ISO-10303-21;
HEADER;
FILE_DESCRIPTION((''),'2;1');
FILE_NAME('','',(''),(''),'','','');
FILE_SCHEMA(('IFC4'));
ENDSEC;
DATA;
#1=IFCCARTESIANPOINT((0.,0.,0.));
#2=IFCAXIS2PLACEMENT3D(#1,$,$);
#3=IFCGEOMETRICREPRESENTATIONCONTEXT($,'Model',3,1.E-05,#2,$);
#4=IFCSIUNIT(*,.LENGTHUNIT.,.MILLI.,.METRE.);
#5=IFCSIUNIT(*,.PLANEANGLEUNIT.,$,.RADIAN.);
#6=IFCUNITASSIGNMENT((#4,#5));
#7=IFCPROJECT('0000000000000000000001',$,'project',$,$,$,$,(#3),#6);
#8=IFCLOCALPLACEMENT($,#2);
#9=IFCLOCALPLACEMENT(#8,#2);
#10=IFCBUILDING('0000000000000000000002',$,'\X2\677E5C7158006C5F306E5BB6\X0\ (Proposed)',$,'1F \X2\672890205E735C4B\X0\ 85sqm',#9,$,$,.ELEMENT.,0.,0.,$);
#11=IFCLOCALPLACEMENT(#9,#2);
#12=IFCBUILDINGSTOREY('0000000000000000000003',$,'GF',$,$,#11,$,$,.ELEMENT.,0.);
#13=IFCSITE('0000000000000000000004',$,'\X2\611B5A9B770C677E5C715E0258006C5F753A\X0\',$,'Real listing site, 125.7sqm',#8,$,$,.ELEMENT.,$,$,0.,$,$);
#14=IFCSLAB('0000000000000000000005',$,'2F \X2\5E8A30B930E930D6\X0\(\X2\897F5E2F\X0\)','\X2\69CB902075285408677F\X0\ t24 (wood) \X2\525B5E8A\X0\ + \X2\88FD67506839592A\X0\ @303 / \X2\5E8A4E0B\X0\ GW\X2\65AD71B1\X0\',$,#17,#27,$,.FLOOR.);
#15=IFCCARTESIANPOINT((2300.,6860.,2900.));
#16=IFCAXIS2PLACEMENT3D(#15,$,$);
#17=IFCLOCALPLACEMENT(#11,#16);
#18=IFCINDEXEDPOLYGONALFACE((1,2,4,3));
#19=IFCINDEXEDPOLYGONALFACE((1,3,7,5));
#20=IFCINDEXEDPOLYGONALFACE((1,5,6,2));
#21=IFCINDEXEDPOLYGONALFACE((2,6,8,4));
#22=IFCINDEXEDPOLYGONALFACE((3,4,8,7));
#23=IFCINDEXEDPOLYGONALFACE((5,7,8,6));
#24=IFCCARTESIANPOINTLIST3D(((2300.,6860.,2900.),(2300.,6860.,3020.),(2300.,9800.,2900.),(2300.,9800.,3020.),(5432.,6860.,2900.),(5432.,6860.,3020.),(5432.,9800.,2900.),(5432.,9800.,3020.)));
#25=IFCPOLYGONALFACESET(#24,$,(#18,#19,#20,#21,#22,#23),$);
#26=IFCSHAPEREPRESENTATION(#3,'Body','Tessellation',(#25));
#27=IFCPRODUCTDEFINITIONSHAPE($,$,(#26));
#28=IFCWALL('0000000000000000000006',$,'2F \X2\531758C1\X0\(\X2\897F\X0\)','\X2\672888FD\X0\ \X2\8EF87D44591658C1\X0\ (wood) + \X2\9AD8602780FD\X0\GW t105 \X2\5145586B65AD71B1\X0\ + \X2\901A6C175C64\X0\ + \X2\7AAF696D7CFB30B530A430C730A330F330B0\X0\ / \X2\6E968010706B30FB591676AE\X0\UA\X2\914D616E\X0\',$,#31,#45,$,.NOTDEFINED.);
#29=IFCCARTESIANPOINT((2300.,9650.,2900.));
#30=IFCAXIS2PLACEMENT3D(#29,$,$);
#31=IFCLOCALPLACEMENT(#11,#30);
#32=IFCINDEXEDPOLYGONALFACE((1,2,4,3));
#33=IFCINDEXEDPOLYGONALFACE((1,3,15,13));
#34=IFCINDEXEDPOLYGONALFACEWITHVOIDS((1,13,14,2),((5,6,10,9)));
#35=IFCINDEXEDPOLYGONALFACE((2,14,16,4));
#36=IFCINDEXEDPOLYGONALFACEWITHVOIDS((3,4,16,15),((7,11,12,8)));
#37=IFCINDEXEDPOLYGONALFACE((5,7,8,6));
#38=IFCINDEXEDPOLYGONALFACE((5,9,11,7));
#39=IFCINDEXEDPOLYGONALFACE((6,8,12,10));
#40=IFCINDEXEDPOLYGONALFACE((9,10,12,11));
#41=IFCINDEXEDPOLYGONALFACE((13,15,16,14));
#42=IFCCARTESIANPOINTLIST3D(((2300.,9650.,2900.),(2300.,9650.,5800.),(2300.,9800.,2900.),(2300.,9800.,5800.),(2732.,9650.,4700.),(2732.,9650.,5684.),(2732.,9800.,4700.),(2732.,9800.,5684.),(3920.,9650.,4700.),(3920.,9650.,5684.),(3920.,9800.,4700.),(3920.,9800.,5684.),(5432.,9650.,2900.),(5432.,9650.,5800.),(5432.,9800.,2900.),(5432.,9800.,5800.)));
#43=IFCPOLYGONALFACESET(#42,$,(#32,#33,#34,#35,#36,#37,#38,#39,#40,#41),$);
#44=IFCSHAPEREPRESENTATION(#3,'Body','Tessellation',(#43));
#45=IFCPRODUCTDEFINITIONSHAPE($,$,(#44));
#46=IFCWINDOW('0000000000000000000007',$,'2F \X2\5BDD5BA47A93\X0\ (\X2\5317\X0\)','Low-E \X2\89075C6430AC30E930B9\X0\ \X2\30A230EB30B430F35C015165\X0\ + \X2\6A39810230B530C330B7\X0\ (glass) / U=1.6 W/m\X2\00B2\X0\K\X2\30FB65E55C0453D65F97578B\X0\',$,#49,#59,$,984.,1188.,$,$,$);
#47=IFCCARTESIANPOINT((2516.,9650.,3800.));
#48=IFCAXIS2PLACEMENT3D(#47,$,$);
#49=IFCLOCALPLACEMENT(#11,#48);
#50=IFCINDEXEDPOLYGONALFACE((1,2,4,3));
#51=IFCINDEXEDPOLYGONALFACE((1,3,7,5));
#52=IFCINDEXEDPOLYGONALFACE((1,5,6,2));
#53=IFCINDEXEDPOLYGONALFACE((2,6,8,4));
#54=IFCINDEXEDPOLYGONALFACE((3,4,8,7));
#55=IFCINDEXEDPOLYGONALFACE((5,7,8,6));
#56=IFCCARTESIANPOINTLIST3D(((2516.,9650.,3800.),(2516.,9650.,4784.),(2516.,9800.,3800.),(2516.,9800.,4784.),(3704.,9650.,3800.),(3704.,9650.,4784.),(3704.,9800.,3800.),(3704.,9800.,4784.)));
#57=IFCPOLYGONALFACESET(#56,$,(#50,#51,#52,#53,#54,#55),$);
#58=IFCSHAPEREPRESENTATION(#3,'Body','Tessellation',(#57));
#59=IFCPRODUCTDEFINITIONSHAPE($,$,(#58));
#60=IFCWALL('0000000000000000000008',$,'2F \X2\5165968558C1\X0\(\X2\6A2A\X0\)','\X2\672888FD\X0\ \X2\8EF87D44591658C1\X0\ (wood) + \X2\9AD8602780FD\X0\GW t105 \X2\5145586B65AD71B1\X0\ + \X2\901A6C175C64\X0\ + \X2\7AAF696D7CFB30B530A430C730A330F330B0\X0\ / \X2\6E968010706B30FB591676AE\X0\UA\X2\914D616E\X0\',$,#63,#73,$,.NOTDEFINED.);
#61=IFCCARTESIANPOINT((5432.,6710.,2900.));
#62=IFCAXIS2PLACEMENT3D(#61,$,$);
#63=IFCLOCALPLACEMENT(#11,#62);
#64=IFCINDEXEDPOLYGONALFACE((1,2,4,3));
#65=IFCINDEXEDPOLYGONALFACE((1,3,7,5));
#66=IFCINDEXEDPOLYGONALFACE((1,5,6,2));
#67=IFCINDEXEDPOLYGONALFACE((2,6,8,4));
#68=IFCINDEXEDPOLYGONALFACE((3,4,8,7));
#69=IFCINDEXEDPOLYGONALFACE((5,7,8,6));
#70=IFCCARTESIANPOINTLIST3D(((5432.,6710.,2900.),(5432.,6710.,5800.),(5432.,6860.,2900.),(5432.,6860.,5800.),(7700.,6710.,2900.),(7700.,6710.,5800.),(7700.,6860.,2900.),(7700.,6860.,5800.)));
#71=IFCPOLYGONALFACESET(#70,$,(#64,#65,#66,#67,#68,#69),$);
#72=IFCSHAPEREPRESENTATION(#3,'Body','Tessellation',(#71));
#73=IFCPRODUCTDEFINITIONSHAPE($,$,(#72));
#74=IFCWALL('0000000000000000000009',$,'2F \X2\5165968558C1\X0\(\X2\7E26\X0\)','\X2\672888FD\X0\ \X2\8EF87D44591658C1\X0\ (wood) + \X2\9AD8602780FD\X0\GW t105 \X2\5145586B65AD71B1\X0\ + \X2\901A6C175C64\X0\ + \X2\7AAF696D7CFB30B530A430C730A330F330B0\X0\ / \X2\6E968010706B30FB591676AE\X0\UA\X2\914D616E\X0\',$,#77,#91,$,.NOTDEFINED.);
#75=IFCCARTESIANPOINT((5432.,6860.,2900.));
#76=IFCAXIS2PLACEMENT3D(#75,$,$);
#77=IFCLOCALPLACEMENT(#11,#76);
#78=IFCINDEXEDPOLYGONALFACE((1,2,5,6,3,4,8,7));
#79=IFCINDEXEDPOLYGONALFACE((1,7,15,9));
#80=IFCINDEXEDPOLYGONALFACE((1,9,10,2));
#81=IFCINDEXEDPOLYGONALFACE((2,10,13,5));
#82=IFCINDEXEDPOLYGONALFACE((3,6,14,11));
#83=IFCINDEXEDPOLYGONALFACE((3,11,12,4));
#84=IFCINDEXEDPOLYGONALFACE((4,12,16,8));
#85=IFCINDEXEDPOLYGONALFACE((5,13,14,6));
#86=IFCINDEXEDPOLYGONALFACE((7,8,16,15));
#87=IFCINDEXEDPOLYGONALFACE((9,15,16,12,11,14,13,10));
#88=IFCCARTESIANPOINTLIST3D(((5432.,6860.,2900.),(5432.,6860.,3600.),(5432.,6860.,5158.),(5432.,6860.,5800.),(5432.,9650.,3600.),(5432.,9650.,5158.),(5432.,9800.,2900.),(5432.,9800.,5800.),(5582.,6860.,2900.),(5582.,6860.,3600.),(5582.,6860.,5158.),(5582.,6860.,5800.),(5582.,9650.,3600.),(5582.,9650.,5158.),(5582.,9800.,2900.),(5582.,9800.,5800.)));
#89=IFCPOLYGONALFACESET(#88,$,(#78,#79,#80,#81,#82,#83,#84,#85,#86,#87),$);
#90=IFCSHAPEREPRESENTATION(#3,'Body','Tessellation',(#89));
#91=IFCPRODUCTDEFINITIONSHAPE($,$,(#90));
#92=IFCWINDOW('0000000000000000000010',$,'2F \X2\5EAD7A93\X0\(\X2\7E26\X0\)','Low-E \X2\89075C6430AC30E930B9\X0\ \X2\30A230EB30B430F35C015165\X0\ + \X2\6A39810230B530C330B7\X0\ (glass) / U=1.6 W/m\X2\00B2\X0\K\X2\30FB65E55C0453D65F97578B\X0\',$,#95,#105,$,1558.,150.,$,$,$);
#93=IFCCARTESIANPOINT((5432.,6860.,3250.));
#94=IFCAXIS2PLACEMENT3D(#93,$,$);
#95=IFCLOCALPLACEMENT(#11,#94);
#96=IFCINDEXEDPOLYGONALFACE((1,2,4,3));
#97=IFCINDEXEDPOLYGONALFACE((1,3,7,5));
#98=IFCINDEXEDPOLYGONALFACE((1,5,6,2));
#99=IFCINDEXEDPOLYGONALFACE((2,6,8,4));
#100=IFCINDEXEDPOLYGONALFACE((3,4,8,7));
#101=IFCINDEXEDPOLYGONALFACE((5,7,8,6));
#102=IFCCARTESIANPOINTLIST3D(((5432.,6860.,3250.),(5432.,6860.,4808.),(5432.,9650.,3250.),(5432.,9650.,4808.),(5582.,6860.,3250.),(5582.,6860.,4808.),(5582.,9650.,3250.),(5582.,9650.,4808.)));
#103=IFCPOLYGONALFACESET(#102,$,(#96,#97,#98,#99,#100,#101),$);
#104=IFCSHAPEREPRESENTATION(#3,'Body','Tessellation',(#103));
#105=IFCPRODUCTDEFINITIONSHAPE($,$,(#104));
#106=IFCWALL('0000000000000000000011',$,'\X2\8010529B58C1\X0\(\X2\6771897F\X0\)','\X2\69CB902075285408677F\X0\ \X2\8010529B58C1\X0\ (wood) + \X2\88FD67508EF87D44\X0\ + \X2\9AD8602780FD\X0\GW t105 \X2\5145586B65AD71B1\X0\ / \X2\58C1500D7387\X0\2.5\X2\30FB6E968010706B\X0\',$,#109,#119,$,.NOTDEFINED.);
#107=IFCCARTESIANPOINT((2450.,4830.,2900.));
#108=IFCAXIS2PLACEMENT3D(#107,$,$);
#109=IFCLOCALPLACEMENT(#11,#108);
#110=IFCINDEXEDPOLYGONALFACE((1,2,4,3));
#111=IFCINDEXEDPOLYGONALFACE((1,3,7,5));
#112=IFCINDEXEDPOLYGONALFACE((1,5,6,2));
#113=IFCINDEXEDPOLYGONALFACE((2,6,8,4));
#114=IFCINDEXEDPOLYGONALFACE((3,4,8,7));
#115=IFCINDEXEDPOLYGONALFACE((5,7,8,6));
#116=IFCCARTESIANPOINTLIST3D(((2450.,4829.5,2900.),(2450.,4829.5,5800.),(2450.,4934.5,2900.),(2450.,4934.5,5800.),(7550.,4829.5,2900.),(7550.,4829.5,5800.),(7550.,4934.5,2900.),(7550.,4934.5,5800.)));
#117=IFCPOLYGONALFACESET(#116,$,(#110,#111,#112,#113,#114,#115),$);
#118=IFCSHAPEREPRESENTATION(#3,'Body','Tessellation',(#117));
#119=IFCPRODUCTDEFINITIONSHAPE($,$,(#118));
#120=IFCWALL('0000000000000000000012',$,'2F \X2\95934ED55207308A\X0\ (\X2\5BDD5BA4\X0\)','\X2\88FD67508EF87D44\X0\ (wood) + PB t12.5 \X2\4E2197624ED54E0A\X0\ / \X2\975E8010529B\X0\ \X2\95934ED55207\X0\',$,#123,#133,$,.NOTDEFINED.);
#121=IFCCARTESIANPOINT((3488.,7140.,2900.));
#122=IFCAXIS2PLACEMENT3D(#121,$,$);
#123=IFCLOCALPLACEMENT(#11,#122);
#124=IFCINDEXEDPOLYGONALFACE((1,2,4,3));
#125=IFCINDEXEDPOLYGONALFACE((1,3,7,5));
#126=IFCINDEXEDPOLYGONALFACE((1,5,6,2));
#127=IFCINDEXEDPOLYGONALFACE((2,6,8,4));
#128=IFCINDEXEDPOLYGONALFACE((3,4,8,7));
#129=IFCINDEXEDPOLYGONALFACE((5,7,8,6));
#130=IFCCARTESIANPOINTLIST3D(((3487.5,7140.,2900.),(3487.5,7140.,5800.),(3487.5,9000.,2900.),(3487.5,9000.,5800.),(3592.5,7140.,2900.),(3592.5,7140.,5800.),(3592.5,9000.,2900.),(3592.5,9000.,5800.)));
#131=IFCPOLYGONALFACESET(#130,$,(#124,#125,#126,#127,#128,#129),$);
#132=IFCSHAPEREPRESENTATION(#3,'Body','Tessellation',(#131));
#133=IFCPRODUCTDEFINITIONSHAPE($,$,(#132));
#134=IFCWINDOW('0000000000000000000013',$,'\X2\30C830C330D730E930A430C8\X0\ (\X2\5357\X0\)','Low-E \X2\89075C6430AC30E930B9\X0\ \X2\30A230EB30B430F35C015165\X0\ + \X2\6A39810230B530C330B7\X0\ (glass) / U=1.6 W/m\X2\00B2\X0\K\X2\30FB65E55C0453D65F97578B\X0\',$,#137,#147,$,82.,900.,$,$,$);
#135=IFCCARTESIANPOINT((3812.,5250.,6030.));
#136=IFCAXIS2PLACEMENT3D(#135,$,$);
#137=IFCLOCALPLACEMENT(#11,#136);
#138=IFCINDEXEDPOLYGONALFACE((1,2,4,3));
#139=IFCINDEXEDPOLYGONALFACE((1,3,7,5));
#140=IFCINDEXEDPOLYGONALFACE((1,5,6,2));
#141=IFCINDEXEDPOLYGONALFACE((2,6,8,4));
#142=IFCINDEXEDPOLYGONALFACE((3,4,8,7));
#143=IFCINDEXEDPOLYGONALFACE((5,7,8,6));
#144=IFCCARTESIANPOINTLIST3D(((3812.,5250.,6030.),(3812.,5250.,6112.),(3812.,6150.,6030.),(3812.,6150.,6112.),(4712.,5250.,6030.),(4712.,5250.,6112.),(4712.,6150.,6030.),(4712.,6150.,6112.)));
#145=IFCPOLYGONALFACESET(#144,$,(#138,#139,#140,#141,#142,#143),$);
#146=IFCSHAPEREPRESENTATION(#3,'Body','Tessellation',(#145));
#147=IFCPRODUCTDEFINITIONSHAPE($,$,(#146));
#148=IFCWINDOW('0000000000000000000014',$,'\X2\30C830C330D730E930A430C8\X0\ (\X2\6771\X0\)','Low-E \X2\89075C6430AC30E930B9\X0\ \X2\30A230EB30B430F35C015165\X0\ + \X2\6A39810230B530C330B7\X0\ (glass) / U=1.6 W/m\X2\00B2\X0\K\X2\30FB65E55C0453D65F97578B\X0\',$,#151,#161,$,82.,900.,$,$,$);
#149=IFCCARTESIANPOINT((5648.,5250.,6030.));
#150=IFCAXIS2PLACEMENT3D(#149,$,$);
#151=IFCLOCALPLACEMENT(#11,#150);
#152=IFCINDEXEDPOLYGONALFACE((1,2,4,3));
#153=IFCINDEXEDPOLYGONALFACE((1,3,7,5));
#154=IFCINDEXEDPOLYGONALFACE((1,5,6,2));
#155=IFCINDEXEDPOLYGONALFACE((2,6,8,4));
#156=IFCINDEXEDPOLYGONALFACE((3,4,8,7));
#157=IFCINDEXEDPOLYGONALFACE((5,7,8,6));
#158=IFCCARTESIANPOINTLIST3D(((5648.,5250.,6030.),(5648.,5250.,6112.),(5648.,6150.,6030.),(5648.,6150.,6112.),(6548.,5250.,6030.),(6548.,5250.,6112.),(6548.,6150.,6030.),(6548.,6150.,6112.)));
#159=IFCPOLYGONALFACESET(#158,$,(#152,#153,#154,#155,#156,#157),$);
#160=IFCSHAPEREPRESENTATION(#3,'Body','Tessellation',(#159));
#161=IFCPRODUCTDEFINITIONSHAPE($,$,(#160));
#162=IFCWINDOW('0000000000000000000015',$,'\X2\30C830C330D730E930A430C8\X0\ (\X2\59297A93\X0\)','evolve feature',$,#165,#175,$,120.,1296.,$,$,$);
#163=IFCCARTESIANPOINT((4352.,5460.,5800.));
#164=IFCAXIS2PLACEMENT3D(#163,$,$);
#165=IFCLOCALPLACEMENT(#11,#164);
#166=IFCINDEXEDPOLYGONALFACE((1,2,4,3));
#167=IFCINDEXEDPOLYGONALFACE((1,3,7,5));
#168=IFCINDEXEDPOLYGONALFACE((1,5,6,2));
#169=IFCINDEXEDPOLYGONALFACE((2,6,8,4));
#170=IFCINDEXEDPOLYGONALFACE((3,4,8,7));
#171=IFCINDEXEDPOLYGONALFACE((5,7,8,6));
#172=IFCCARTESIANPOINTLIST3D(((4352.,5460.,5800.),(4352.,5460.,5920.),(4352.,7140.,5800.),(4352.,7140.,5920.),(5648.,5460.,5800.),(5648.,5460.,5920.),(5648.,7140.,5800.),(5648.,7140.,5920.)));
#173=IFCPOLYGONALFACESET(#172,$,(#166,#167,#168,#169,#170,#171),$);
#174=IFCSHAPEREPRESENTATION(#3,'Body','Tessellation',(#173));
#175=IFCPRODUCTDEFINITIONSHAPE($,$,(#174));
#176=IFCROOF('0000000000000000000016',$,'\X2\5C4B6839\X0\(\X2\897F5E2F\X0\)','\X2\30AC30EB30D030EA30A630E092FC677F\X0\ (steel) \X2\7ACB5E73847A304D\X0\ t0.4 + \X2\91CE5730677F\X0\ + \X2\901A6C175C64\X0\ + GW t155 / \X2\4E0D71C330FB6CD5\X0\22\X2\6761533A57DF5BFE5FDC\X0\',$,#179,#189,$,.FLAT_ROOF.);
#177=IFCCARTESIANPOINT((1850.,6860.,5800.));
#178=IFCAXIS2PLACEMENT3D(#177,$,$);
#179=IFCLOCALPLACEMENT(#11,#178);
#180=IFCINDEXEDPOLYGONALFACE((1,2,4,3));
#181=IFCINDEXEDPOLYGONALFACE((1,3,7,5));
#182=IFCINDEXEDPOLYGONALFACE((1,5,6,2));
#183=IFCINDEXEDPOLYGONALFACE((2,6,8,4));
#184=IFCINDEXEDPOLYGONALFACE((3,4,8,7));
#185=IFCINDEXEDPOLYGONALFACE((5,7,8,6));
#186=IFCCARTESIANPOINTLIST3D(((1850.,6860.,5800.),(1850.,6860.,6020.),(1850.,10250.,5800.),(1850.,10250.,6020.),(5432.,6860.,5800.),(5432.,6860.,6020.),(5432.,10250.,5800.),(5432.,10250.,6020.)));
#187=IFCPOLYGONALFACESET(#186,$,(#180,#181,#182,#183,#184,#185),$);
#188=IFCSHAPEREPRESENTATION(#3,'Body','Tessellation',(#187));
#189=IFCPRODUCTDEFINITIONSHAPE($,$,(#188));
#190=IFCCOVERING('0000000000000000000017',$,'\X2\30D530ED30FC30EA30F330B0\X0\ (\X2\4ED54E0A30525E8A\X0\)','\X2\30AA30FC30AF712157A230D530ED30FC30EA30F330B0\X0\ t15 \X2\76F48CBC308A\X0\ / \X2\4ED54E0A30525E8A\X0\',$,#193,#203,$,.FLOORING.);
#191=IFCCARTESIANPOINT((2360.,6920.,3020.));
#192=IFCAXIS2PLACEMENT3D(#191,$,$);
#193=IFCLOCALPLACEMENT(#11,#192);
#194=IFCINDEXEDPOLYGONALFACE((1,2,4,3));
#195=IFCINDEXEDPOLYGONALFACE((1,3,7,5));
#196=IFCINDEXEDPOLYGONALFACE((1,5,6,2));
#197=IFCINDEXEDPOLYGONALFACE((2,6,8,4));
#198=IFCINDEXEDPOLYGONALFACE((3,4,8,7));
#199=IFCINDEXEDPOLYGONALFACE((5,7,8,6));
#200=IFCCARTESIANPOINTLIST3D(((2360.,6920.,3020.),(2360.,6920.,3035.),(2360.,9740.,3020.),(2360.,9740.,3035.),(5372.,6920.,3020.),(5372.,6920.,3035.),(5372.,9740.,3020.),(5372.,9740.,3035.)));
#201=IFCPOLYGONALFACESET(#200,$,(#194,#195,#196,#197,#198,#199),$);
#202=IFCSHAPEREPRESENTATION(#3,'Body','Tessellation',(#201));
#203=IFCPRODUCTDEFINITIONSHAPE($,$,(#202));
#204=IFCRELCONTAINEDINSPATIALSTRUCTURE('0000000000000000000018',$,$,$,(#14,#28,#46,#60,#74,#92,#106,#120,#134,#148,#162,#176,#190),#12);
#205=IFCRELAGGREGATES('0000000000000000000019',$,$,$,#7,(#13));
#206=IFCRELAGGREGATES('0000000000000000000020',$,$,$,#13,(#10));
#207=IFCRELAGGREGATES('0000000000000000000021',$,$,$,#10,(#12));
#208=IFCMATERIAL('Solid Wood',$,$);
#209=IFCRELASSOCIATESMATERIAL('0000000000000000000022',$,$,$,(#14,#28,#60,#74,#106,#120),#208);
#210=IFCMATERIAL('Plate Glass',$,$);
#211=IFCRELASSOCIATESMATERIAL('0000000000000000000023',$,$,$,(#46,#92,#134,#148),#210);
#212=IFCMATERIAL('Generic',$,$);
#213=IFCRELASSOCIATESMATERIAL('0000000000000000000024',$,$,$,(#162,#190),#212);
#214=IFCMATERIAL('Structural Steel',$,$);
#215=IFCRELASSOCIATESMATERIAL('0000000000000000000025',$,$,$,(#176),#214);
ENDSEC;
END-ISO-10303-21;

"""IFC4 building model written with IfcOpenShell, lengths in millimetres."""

from ifc_helpers import new_model, si_unit, frame, frame_2d, origin, place, context, project, spatial, rectangle, extrude, material, element, fill, save


model = new_model("IFC4")

# Units and contexts
model_context = context("Model", 3, precision=1e-05, world=origin())
ifc_project = project(units=[si_unit("LENGTHUNIT", "METRE", prefix="MILLI"), si_unit("PLANEANGLEUNIT", "RADIAN")], contexts=[model_context])

# Site, building, storey
site_placement = place(None, origin())
site = spatial("IfcSite", under=ifc_project, at=site_placement, Name="愛媛県松山市堀江町", ObjectType="Real listing site, 125.7sqm", CompositionType="ELEMENT", RefElevation=0.0)
building_placement = place(site_placement, origin())
building = spatial("IfcBuilding", under=site, at=building_placement, Name="松山堀江の家 (Proposed)", ObjectType="1F 木造平屋 85sqm", CompositionType="ELEMENT", ElevationOfRefHeight=0.0, ElevationOfTerrain=0.0)
storey_placement = place(building_placement, origin())
storey = spatial("IfcBuildingStorey", under=building, at=storey_placement, Name="GF", CompositionType="ELEMENT", Elevation=0.0)

# Slab
ifc_material_1 = material(Name="Solid Wood")
slab_placement = place(storey_placement, frame((2300.0, 6860.0, 2900.0)))
element("IfcSlab", 1, at=slab_placement, inside=storey, material=ifc_material_1, Name="2F 床スラブ(西帯)", Description="構造用合板 t24 (wood) 剛床 + 製材根太 @303 / 床下 GW断熱", PredefinedType="FLOOR", context=model_context, shape_type="SweptSolid", body=[
    extrude(rectangle(XDim=3132.0, YDim=2940.0, at=frame_2d((1566.0, 1470.0))), frame((2300.0, 6860.0, 2900.0)), (0.0, 0.0, 1.0), 120.0),
])

# Wall, opening, window
wall_1_placement = place(storey_placement, frame((2300.0, 9650.0, 2900.0)))
wall_1 = element("IfcWall", 2, at=wall_1_placement, inside=storey, material=ifc_material_1, Name="2F 北壁(西)", Description="木製 軸組外壁 (wood) + 高性能GW t105 充填断熱 + 通気層 + 窯業系サイディング / 準耐火・外皮UA配慮", PredefinedType="NOTDEFINED", context=model_context, shape_type="SweptSolid", body=[
    extrude(rectangle(XDim=3132.0, YDim=150.0, at=frame_2d((1566.0, 75.0))), frame((2300.0, 9650.0, 2900.0)), (0.0, 0.0, 1.0), 2900.0),
])
opening_1_placement = place(storey_placement, frame((2516.0, 9650.0, 3800.0)))
opening_1 = element("IfcOpeningElement", 3, at=opening_1_placement, cuts=wall_1, PredefinedType="NOTDEFINED", context=model_context, shape_type="SweptSolid", body=[
    extrude(rectangle(XDim=1188.0, YDim=150.0, at=frame_2d((594.0, 75.0))), frame((2516.0, 9650.0, 3800.0)), (0.0, 0.0, 1.0), 984.0),
])
ifc_material_2 = material(Name="Plate Glass")
window_1_placement = place(storey_placement, frame((2516.0, 9650.0, 3800.0)))
window_1 = element("IfcWindow", 4, at=window_1_placement, inside=storey, material=ifc_material_2, Name="2F 寝室窓 (北)", Description="Low-E 複層ガラス アルゴン封入 + 樹脂サッシ (glass) / U=1.6 W/m²K・日射取得型", OverallHeight=984.0, OverallWidth=1188.0, context=model_context, shape_type="SweptSolid", body=[
    extrude(rectangle(XDim=1188.0, YDim=150.0, at=frame_2d((594.0, 75.0))), frame((2516.0, 9650.0, 3800.0)), (0.0, 0.0, 1.0), 984.0),
])
fill(opening_1, window_1)

# Wall
wall_2_placement = place(storey_placement, frame((5432.0, 6710.0, 2900.0)))
element("IfcWall", 5, at=wall_2_placement, inside=storey, material=ifc_material_1, Name="2F 入隅壁(横)", Description="木製 軸組外壁 (wood) + 高性能GW t105 充填断熱 + 通気層 + 窯業系サイディング / 準耐火・外皮UA配慮", PredefinedType="NOTDEFINED", context=model_context, shape_type="SweptSolid", body=[
    extrude(rectangle(XDim=2268.0, YDim=150.0, at=frame_2d((1134.0, 75.0))), frame((5432.0, 6710.0, 2900.0)), (0.0, 0.0, 1.0), 2900.0),
])

# Wall, opening, window
wall_3_placement = place(storey_placement, frame((5432.0, 6860.0, 2900.0)))
wall_3 = element("IfcWall", 6, at=wall_3_placement, inside=storey, material=ifc_material_1, Name="2F 入隅壁(縦)", Description="木製 軸組外壁 (wood) + 高性能GW t105 充填断熱 + 通気層 + 窯業系サイディング / 準耐火・外皮UA配慮", PredefinedType="NOTDEFINED", context=model_context, shape_type="SweptSolid", body=[
    extrude(rectangle(XDim=150.0, YDim=2940.0, at=frame_2d((75.0, 1470.0))), frame((5432.0, 6860.0, 2900.0)), (0.0, 0.0, 1.0), 2900.0),
])
opening_2_placement = place(storey_placement, frame((5432.0, 6860.0, 3250.0)))
opening_2 = element("IfcOpeningElement", 7, at=opening_2_placement, cuts=wall_3, PredefinedType="NOTDEFINED", context=model_context, shape_type="SweptSolid", body=[
    extrude(rectangle(XDim=150.0, YDim=2790.0, at=frame_2d((75.0, 1395.0))), frame((5432.0, 6860.0, 3250.0)), (0.0, 0.0, 1.0), 1558.0),
])
window_2_placement = place(storey_placement, frame((5432.0, 6860.0, 3250.0)))
window_2 = element("IfcWindow", 8, at=window_2_placement, inside=storey, material=ifc_material_2, Name="2F 庭窓(縦)", Description="Low-E 複層ガラス アルゴン封入 + 樹脂サッシ (glass) / U=1.6 W/m²K・日射取得型", OverallHeight=1558.0, OverallWidth=150.0, context=model_context, shape_type="SweptSolid", body=[
    extrude(rectangle(XDim=150.0, YDim=2790.0, at=frame_2d((75.0, 1395.0))), frame((5432.0, 6860.0, 3250.0)), (0.0, 0.0, 1.0), 1558.0),
])
fill(opening_2, window_2)

# Walls
wall_4_placement = place(storey_placement, frame((2450.0, 4830.0, 2900.0)))
element("IfcWall", 9, at=wall_4_placement, inside=storey, material=ifc_material_1, Name="耐力壁(東西)", Description="構造用合板 耐力壁 (wood) + 製材軸組 + 高性能GW t105 充填断熱 / 壁倍率2.5・準耐火", PredefinedType="NOTDEFINED", context=model_context, shape_type="SweptSolid", body=[
    extrude(rectangle(XDim=5100.0, YDim=105.0, at=frame_2d((2550.0, 52.0))), frame((2450.0, 4830.0, 2900.0)), (0.0, 0.0, 1.0), 2900.0),
])
wall_5_placement = place(storey_placement, frame((3488.0, 7140.0, 2900.0)))
element("IfcWall", 10, at=wall_5_placement, inside=storey, material=ifc_material_1, Name="2F 間仕切り (寝室)", Description="製材軸組 (wood) + PB t12.5 両面仕上 / 非耐力 間仕切", PredefinedType="NOTDEFINED", context=model_context, shape_type="SweptSolid", body=[
    extrude(rectangle(XDim=105.0, YDim=1860.0, at=frame_2d((52.0, 930.0))), frame((3488.0, 7140.0, 2900.0)), (0.0, 0.0, 1.0), 2900.0),
])

# Windows
window_3_placement = place(storey_placement, frame((3812.0, 5250.0, 6030.0)))
element("IfcWindow", 11, at=window_3_placement, inside=storey, material=ifc_material_2, Name="トップライト (南)", Description="Low-E 複層ガラス アルゴン封入 + 樹脂サッシ (glass) / U=1.6 W/m²K・日射取得型", OverallHeight=82.0, OverallWidth=900.0, context=model_context, shape_type="SweptSolid", body=[
    extrude(rectangle(XDim=900.0, YDim=900.0, at=frame_2d((450.0, 450.0))), frame((3812.0, 5250.0, 6030.0)), (0.0, 0.0, 1.0), 82.0),
])
window_4_placement = place(storey_placement, frame((5648.0, 5250.0, 6030.0)))
element("IfcWindow", 12, at=window_4_placement, inside=storey, material=ifc_material_2, Name="トップライト (東)", Description="Low-E 複層ガラス アルゴン封入 + 樹脂サッシ (glass) / U=1.6 W/m²K・日射取得型", OverallHeight=82.0, OverallWidth=900.0, context=model_context, shape_type="SweptSolid", body=[
    extrude(rectangle(XDim=900.0, YDim=900.0, at=frame_2d((450.0, 450.0))), frame((5648.0, 5250.0, 6030.0)), (0.0, 0.0, 1.0), 82.0),
])
ifc_material_3 = material(Name="Generic")
window_5_placement = place(storey_placement, frame((4352.0, 5460.0, 5800.0)))
element("IfcWindow", 13, at=window_5_placement, inside=storey, material=ifc_material_3, Name="トップライト (天窓)", Description="evolve feature", OverallHeight=120.0, OverallWidth=1296.0, context=model_context, shape_type="SweptSolid", body=[
    extrude(rectangle(XDim=1296.0, YDim=1680.0, at=frame_2d((648.0, 840.0))), frame((4352.0, 5460.0, 5800.0)), (0.0, 0.0, 1.0), 120.0),
])

# Roof
ifc_material_4 = material(Name="Structural Steel")
for number, where, name in (
    (14, (1850.0, 6860.0, 5800.0), "屋根(西帯)"),
):
    element("IfcRoof", number, at=place(storey_placement, frame(where)), inside=storey, material=ifc_material_4, Name=name, Description="ガルバリウム鋼板 (steel) 立平葺き t0.4 + 野地板 + 通気層 + GW t155 / 不燃・法22条区域対応", PredefinedType="FLAT_ROOF", context=model_context, shape_type="SweptSolid", body=[
        extrude(rectangle(XDim=3582.0, YDim=3390.0, at=frame_2d((1791.0, 1695.0))), frame((1850.0, 6860.0, 5800.0)), (0.0, 0.0, 1.0), 220.0),
    ])

# Covering
covering_placement = place(storey_placement, frame((2360.0, 6920.0, 3020.0)))
element("IfcCovering", 15, at=covering_placement, inside=storey, material=ifc_material_3, Name="フローリング (仕上げ床)", Description="オーク無垢フローリング t15 直貼り / 仕上げ床", PredefinedType="FLOORING", context=model_context, shape_type="SweptSolid", body=[
    extrude(rectangle(XDim=3012.0, YDim=2820.0, at=frame_2d((1506.0, 1410.0))), frame((2360.0, 6920.0, 3020.0)), (0.0, 0.0, 1.0), 15.0),
])

save(model, "model.ifc")
